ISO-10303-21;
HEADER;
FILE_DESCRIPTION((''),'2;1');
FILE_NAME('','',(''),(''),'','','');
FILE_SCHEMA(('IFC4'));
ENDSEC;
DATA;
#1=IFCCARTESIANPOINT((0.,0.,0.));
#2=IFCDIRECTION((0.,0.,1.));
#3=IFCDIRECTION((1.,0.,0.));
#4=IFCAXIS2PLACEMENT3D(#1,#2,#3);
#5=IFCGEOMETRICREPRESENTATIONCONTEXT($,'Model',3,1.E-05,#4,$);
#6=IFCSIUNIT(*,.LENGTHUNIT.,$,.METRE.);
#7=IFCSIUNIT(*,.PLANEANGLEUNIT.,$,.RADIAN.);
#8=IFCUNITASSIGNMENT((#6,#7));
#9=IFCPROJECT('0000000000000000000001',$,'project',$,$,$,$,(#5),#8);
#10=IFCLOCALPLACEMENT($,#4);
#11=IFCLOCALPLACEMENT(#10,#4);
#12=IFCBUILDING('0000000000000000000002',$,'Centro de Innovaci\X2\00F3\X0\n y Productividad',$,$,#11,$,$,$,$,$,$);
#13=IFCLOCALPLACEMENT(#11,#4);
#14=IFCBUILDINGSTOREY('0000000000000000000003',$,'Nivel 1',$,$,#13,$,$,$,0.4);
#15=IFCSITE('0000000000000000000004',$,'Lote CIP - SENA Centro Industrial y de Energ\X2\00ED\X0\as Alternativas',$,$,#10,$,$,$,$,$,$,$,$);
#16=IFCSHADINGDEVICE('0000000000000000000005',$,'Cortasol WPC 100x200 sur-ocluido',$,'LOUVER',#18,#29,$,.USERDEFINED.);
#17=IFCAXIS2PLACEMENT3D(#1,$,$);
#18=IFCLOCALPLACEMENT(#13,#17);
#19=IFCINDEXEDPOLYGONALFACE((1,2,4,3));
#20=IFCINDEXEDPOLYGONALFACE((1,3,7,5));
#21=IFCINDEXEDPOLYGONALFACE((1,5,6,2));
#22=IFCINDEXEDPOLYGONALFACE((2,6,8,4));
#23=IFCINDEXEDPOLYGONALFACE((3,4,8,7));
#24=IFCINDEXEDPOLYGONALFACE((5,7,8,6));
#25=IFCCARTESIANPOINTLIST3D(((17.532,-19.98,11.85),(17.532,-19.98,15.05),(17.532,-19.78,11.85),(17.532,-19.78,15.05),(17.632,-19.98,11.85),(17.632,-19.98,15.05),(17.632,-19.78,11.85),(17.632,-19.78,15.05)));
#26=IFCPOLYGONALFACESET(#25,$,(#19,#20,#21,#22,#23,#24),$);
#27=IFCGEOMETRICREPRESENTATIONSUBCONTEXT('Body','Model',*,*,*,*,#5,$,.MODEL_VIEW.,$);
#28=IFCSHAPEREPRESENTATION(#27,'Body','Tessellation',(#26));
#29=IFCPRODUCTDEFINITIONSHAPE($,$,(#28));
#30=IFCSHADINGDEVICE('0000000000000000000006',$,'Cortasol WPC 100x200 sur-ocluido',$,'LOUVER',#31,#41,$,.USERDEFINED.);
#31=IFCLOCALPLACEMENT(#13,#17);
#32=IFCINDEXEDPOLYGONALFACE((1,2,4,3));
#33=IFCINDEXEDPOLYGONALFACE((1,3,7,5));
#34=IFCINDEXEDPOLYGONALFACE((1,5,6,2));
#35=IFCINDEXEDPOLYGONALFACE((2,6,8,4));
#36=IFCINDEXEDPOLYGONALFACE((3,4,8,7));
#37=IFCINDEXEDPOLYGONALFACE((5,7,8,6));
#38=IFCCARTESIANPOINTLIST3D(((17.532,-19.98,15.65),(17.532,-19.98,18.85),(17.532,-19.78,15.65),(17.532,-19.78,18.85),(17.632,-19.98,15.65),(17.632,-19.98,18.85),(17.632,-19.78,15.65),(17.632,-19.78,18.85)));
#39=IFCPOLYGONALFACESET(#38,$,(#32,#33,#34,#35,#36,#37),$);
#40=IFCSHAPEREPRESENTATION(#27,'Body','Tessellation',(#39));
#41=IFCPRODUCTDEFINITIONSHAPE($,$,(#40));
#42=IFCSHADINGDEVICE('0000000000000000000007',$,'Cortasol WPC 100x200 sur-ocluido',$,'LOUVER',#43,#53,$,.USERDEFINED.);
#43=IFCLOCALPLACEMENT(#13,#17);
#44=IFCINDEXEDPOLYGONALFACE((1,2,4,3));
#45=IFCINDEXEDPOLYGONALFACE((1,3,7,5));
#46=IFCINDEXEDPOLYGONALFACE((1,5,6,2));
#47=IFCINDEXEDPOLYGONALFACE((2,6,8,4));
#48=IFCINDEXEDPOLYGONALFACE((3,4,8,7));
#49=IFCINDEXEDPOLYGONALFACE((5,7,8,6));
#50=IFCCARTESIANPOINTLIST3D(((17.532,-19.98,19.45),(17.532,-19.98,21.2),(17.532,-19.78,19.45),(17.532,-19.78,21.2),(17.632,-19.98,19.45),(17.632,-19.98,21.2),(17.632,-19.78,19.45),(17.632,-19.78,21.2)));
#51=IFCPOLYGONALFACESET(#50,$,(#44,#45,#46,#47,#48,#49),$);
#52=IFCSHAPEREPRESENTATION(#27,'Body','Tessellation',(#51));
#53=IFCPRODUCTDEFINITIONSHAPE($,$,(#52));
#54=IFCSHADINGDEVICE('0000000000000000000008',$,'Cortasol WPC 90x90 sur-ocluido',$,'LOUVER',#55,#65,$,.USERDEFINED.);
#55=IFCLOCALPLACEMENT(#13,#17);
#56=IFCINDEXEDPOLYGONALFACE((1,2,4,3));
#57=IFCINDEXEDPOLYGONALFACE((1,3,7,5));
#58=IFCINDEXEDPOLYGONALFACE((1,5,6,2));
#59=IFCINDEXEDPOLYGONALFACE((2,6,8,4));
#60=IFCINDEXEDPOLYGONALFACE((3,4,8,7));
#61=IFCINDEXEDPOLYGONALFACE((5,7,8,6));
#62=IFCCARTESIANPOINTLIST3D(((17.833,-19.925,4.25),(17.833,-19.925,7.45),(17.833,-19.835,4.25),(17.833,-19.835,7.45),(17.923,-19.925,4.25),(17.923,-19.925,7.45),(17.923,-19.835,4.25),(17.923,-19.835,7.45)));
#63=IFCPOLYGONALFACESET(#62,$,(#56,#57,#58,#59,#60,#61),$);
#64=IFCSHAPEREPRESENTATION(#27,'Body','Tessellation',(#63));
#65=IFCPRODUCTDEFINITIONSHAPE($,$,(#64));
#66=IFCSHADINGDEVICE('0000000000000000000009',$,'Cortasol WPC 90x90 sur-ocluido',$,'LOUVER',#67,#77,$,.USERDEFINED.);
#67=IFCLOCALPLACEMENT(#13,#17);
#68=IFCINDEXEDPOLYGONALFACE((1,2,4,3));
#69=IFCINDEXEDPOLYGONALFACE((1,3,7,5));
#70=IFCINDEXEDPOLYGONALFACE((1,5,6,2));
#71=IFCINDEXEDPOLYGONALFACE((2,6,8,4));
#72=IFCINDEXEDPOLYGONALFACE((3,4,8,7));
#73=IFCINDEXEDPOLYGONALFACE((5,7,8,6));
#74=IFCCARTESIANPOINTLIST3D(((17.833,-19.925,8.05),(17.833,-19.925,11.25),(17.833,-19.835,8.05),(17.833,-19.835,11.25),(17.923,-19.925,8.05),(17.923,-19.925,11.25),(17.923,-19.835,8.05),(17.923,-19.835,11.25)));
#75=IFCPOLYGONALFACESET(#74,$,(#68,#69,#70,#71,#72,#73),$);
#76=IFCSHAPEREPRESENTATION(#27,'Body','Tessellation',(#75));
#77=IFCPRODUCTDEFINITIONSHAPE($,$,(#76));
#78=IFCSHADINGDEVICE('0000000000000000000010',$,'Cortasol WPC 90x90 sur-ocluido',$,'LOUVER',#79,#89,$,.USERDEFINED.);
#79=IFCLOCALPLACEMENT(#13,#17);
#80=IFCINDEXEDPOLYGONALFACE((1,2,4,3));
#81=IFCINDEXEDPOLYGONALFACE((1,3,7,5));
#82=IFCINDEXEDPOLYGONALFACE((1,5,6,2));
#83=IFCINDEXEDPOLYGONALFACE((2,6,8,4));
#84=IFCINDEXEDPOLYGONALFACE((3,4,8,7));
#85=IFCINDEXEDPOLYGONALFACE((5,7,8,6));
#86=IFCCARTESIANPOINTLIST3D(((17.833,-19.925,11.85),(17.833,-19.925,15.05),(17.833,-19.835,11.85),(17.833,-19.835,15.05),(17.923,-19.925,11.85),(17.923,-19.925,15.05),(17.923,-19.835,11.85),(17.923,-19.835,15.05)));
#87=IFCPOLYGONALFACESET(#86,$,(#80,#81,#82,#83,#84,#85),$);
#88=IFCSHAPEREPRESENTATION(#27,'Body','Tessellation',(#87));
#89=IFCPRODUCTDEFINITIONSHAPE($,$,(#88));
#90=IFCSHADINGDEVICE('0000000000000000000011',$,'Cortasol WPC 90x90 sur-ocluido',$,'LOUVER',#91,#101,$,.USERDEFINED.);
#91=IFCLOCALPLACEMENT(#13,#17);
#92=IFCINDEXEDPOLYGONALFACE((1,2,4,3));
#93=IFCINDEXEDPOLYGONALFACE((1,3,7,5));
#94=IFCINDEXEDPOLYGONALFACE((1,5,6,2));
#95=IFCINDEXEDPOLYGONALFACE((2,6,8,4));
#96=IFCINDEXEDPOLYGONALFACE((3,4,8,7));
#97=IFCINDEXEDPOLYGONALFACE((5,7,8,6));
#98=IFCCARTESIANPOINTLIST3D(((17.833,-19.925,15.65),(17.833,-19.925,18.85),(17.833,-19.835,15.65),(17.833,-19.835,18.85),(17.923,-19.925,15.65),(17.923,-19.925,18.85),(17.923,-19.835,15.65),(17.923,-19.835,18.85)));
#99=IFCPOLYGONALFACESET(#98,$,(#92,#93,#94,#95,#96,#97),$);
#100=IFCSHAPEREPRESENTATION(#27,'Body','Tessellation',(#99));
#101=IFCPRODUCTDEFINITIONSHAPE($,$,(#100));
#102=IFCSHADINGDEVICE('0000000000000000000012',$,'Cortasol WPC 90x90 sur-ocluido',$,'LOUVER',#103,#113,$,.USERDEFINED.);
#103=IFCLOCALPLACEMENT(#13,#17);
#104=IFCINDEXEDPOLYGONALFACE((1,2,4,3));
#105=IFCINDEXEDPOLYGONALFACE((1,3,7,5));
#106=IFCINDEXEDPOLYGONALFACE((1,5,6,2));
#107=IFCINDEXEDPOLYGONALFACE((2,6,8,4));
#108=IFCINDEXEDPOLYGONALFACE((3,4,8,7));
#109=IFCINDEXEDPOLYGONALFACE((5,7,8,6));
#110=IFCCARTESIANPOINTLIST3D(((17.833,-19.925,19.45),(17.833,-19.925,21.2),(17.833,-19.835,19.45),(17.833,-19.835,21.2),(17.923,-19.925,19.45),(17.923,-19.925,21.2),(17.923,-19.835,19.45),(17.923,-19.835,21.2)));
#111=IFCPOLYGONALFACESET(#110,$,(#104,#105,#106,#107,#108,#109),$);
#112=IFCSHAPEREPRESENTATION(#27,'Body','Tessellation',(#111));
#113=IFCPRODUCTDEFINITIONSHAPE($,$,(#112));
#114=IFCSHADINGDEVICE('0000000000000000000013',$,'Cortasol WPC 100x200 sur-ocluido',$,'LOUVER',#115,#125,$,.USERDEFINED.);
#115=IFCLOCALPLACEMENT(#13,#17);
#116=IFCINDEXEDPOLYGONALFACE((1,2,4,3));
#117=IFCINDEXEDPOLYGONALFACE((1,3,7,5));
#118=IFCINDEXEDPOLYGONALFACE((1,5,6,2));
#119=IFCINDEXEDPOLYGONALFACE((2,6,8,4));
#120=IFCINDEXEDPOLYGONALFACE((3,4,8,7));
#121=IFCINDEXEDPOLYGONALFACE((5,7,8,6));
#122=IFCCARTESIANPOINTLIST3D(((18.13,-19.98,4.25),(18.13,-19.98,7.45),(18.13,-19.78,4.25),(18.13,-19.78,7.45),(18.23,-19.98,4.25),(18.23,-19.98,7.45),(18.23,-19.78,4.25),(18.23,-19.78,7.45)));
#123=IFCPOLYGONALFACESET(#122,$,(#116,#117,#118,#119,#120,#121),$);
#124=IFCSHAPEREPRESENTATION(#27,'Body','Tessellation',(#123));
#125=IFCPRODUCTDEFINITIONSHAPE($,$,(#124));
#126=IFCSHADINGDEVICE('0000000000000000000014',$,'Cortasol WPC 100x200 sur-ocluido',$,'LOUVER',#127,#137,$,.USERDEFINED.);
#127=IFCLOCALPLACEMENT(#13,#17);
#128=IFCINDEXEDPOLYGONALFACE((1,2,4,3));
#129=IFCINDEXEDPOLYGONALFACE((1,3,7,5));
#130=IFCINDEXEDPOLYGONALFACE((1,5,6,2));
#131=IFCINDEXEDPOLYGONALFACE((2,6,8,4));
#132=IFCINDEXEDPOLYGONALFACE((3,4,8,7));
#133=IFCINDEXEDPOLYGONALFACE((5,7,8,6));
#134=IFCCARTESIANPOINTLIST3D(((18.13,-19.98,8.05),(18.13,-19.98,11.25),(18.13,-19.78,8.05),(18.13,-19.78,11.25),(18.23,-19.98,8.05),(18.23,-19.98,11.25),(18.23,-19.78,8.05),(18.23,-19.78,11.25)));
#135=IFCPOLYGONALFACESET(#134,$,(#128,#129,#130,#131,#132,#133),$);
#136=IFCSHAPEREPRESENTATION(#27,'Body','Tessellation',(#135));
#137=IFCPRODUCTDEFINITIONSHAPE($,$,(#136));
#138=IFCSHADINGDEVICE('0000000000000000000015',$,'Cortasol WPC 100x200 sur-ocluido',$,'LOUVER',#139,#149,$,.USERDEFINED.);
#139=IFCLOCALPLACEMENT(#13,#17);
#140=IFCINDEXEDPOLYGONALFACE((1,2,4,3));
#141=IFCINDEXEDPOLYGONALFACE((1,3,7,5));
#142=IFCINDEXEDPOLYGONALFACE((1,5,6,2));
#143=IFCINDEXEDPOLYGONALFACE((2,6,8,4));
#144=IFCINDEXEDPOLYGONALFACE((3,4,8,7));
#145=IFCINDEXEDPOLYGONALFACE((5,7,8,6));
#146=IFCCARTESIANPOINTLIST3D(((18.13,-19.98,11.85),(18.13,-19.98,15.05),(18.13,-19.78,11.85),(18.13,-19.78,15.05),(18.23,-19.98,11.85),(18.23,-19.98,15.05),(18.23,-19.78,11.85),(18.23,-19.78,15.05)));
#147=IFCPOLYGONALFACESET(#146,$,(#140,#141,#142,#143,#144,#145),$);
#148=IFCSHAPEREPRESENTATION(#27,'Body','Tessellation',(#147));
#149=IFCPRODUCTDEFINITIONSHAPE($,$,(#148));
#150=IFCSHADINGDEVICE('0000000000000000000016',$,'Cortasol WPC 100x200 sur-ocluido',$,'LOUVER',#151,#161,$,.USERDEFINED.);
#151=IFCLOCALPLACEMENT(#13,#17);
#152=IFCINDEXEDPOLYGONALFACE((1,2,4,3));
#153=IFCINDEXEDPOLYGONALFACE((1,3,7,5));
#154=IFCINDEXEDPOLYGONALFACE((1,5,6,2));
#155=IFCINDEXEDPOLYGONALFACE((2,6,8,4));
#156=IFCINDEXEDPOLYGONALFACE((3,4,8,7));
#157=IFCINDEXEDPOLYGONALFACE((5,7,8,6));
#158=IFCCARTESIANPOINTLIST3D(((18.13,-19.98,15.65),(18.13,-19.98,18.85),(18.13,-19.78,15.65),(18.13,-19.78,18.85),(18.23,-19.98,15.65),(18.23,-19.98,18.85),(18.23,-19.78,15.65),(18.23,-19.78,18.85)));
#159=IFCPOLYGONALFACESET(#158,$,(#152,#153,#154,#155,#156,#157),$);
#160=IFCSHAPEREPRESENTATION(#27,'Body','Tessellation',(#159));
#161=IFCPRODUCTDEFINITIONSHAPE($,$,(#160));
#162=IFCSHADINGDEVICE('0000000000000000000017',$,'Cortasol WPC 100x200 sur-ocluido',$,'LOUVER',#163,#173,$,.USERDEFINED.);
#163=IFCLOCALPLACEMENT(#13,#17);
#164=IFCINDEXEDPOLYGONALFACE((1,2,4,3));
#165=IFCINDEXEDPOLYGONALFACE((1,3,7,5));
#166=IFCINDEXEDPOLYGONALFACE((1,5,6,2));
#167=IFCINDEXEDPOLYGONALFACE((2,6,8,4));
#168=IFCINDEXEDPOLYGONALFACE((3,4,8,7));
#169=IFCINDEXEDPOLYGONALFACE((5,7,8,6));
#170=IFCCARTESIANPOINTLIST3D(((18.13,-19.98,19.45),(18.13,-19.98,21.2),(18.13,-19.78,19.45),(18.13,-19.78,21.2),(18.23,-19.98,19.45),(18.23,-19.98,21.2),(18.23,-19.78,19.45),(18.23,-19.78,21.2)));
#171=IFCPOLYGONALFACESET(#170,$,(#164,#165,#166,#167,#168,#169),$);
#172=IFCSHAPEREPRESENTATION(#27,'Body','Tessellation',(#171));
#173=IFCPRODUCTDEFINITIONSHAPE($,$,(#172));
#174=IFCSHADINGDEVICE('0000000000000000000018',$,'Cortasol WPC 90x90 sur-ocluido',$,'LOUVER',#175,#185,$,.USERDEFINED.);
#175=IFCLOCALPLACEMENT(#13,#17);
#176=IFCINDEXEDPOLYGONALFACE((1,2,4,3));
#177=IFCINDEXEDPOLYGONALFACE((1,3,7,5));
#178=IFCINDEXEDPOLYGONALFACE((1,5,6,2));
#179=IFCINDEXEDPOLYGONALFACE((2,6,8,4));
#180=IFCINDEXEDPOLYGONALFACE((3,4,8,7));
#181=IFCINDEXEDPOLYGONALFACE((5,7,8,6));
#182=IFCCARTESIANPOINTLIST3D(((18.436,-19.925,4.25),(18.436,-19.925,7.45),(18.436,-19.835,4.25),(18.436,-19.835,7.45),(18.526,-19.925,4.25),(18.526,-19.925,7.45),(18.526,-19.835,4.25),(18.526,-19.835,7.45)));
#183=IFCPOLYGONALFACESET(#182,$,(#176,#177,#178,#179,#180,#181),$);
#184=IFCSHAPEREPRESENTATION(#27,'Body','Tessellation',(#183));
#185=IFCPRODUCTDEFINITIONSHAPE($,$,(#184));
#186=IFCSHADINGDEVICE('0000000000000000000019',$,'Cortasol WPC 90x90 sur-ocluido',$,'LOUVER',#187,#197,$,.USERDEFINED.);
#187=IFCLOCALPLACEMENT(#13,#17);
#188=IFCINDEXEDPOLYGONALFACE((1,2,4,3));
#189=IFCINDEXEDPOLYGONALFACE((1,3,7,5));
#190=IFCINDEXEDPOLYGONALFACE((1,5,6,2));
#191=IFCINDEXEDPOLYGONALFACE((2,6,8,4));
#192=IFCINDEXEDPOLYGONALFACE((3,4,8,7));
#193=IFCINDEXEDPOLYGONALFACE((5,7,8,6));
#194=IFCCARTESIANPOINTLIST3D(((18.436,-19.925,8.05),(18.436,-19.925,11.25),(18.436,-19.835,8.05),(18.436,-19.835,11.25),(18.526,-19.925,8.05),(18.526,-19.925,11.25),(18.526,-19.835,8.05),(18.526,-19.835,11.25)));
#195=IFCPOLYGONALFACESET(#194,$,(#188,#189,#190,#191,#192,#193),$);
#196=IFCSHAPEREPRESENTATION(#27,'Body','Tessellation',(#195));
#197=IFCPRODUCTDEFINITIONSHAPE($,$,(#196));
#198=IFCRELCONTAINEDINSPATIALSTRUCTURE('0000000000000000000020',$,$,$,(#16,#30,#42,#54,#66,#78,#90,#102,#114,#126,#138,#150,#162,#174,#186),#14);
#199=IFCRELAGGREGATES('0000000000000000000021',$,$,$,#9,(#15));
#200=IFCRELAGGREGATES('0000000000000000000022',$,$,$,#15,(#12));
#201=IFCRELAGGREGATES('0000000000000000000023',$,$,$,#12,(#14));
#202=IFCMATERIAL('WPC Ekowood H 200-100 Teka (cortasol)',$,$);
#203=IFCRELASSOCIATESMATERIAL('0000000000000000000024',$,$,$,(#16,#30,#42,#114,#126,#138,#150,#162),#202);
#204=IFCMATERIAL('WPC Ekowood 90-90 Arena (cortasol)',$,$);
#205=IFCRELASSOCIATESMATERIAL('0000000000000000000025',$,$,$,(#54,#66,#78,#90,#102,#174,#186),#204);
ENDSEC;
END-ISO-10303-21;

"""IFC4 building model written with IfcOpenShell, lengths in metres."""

from ifc_helpers import new_model, si_unit, frame, origin_with_axes, place, context, subcontext, project, spatial, polyline, outline, extrude, material, element, save


model = new_model("IFC4")

# Units and contexts
model_context = context("Model", 3, precision=1e-05, world=origin_with_axes())
body_context = subcontext(model_context, "Body", "Model", "MODEL_VIEW")
ifc_project = project(units=[si_unit("LENGTHUNIT", "METRE"), si_unit("PLANEANGLEUNIT", "RADIAN")], contexts=[model_context])

# Site, building, storey
site_placement = place(None, origin_with_axes())
site = spatial("IfcSite", under=ifc_project, at=site_placement, Name="Lote CIP - SENA Centro Industrial y de Energías Alternativas")
building_placement = place(site_placement, origin_with_axes())
building = spatial("IfcBuilding", under=site, at=building_placement, Name="Centro de Innovación y Productividad")
storey_placement = place(building_placement, origin_with_axes())
storey = spatial("IfcBuildingStorey", under=building, at=storey_placement, Name="Nivel 1", Elevation=0.4)

# Shading devices
ifc_material_1 = material(Name="WPC Ekowood H 200-100 Teka (cortasol)")
shading_device_1_placement = place(storey_placement, origin_with_axes())
element("IfcShadingDevice", 1, at=shading_device_1_placement, inside=storey, material=ifc_material_1, Name="Cortasol WPC 100x200 sur-ocluido", ObjectType="LOUVER", PredefinedType="USERDEFINED", context=body_context, shape_type="SweptSolid", body=[
    extrude(outline(polyline([(17.532, -19.98), (17.532, -19.78), (17.632, -19.78), (17.632, -19.98), (17.532, -19.98)])), frame((0.0, 0.0, 11.85)), (0.0, 0.0, 1.0), 3.2),
])
shading_device_2_placement = place(storey_placement, origin_with_axes())
element("IfcShadingDevice", 2, at=shading_device_2_placement, inside=storey, material=ifc_material_1, Name="Cortasol WPC 100x200 sur-ocluido", ObjectType="LOUVER", PredefinedType="USERDEFINED", context=body_context, shape_type="SweptSolid", body=[
    extrude(outline(polyline([(17.532, -19.98), (17.532, -19.78), (17.632, -19.78), (17.632, -19.98), (17.532, -19.98)])), frame((0.0, 0.0, 15.65)), (0.0, 0.0, 1.0), 3.2),
])
shading_device_3_placement = place(storey_placement, origin_with_axes())
element("IfcShadingDevice", 3, at=shading_device_3_placement, inside=storey, material=ifc_material_1, Name="Cortasol WPC 100x200 sur-ocluido", ObjectType="LOUVER", PredefinedType="USERDEFINED", context=body_context, shape_type="SweptSolid", body=[
    extrude(outline(polyline([(17.532, -19.98), (17.532, -19.78), (17.632, -19.78), (17.632, -19.98), (17.532, -19.98)])), frame((0.0, 0.0, 19.45)), (0.0, 0.0, 1.0), 1.75),
])
ifc_material_2 = material(Name="WPC Ekowood 90-90 Arena (cortasol)")
shading_device_4_placement = place(storey_placement, origin_with_axes())
element("IfcShadingDevice", 4, at=shading_device_4_placement, inside=storey, material=ifc_material_2, Name="Cortasol WPC 90x90 sur-ocluido", ObjectType="LOUVER", PredefinedType="USERDEFINED", context=body_context, shape_type="SweptSolid", body=[
    extrude(outline(polyline([(17.833, -19.925), (17.833, -19.835), (17.923, -19.835), (17.923, -19.925), (17.833, -19.925)])), frame((0.0, 0.0, 4.25)), (0.0, 0.0, 1.0), 3.2),
])
shading_device_5_placement = place(storey_placement, origin_with_axes())
element("IfcShadingDevice", 5, at=shading_device_5_placement, inside=storey, material=ifc_material_2, Name="Cortasol WPC 90x90 sur-ocluido", ObjectType="LOUVER", PredefinedType="USERDEFINED", context=body_context, shape_type="SweptSolid", body=[
    extrude(outline(polyline([(17.833, -19.925), (17.833, -19.835), (17.923, -19.835), (17.923, -19.925), (17.833, -19.925)])), frame((0.0, 0.0, 8.05)), (0.0, 0.0, 1.0), 3.2),
])
shading_device_6_placement = place(storey_placement, origin_with_axes())
element("IfcShadingDevice", 6, at=shading_device_6_placement, inside=storey, material=ifc_material_2, Name="Cortasol WPC 90x90 sur-ocluido", ObjectType="LOUVER", PredefinedType="USERDEFINED", context=body_context, shape_type="SweptSolid", body=[
    extrude(outline(polyline([(17.833, -19.925), (17.833, -19.835), (17.923, -19.835), (17.923, -19.925), (17.833, -19.925)])), frame((0.0, 0.0, 11.85)), (0.0, 0.0, 1.0), 3.2),
])
shading_device_7_placement = place(storey_placement, origin_with_axes())
element("IfcShadingDevice", 7, at=shading_device_7_placement, inside=storey, material=ifc_material_2, Name="Cortasol WPC 90x90 sur-ocluido", ObjectType="LOUVER", PredefinedType="USERDEFINED", context=body_context, shape_type="SweptSolid", body=[
    extrude(outline(polyline([(17.833, -19.925), (17.833, -19.835), (17.923, -19.835), (17.923, -19.925), (17.833, -19.925)])), frame((0.0, 0.0, 15.65)), (0.0, 0.0, 1.0), 3.2),
])
shading_device_8_placement = place(storey_placement, origin_with_axes())
element("IfcShadingDevice", 8, at=shading_device_8_placement, inside=storey, material=ifc_material_2, Name="Cortasol WPC 90x90 sur-ocluido", ObjectType="LOUVER", PredefinedType="USERDEFINED", context=body_context, shape_type="SweptSolid", body=[
    extrude(outline(polyline([(17.833, -19.925), (17.833, -19.835), (17.923, -19.835), (17.923, -19.925), (17.833, -19.925)])), frame((0.0, 0.0, 19.45)), (0.0, 0.0, 1.0), 1.75),
])
shading_device_9_placement = place(storey_placement, origin_with_axes())
element("IfcShadingDevice", 9, at=shading_device_9_placement, inside=storey, material=ifc_material_1, Name="Cortasol WPC 100x200 sur-ocluido", ObjectType="LOUVER", PredefinedType="USERDEFINED", context=body_context, shape_type="SweptSolid", body=[
    extrude(outline(polyline([(18.13, -19.98), (18.13, -19.78), (18.23, -19.78), (18.23, -19.98), (18.13, -19.98)])), frame((0.0, 0.0, 4.25)), (0.0, 0.0, 1.0), 3.2),
])
shading_device_10_placement = place(storey_placement, origin_with_axes())
element("IfcShadingDevice", 10, at=shading_device_10_placement, inside=storey, material=ifc_material_1, Name="Cortasol WPC 100x200 sur-ocluido", ObjectType="LOUVER", PredefinedType="USERDEFINED", context=body_context, shape_type="SweptSolid", body=[
    extrude(outline(polyline([(18.13, -19.98), (18.13, -19.78), (18.23, -19.78), (18.23, -19.98), (18.13, -19.98)])), frame((0.0, 0.0, 8.05)), (0.0, 0.0, 1.0), 3.2),
])
shading_device_11_placement = place(storey_placement, origin_with_axes())
element("IfcShadingDevice", 11, at=shading_device_11_placement, inside=storey, material=ifc_material_1, Name="Cortasol WPC 100x200 sur-ocluido", ObjectType="LOUVER", PredefinedType="USERDEFINED", context=body_context, shape_type="SweptSolid", body=[
    extrude(outline(polyline([(18.13, -19.98), (18.13, -19.78), (18.23, -19.78), (18.23, -19.98), (18.13, -19.98)])), frame((0.0, 0.0, 11.85)), (0.0, 0.0, 1.0), 3.2),
])
shading_device_12_placement = place(storey_placement, origin_with_axes())
element("IfcShadingDevice", 12, at=shading_device_12_placement, inside=storey, material=ifc_material_1, Name="Cortasol WPC 100x200 sur-ocluido", ObjectType="LOUVER", PredefinedType="USERDEFINED", context=body_context, shape_type="SweptSolid", body=[
    extrude(outline(polyline([(18.13, -19.98), (18.13, -19.78), (18.23, -19.78), (18.23, -19.98), (18.13, -19.98)])), frame((0.0, 0.0, 15.65)), (0.0, 0.0, 1.0), 3.2),
])
shading_device_13_placement = place(storey_placement, origin_with_axes())
element("IfcShadingDevice", 13, at=shading_device_13_placement, inside=storey, material=ifc_material_1, Name="Cortasol WPC 100x200 sur-ocluido", ObjectType="LOUVER", PredefinedType="USERDEFINED", context=body_context, shape_type="SweptSolid", body=[
    extrude(outline(polyline([(18.13, -19.98), (18.13, -19.78), (18.23, -19.78), (18.23, -19.98), (18.13, -19.98)])), frame((0.0, 0.0, 19.45)), (0.0, 0.0, 1.0), 1.75),
])
shading_device_14_placement = place(storey_placement, origin_with_axes())
element("IfcShadingDevice", 14, at=shading_device_14_placement, inside=storey, material=ifc_material_2, Name="Cortasol WPC 90x90 sur-ocluido", ObjectType="LOUVER", PredefinedType="USERDEFINED", context=body_context, shape_type="SweptSolid", body=[
    extrude(outline(polyline([(18.436, -19.925), (18.436, -19.835), (18.526, -19.835), (18.526, -19.925), (18.436, -19.925)])), frame((0.0, 0.0, 4.25)), (0.0, 0.0, 1.0), 3.2),
])
shading_device_15_placement = place(storey_placement, origin_with_axes())
element("IfcShadingDevice", 15, at=shading_device_15_placement, inside=storey, material=ifc_material_2, Name="Cortasol WPC 90x90 sur-ocluido", ObjectType="LOUVER", PredefinedType="USERDEFINED", context=body_context, shape_type="SweptSolid", body=[
    extrude(outline(polyline([(18.436, -19.925), (18.436, -19.835), (18.526, -19.835), (18.526, -19.925), (18.436, -19.925)])), frame((0.0, 0.0, 8.05)), (0.0, 0.0, 1.0), 3.2),
])

save(model, "model.ifc")
